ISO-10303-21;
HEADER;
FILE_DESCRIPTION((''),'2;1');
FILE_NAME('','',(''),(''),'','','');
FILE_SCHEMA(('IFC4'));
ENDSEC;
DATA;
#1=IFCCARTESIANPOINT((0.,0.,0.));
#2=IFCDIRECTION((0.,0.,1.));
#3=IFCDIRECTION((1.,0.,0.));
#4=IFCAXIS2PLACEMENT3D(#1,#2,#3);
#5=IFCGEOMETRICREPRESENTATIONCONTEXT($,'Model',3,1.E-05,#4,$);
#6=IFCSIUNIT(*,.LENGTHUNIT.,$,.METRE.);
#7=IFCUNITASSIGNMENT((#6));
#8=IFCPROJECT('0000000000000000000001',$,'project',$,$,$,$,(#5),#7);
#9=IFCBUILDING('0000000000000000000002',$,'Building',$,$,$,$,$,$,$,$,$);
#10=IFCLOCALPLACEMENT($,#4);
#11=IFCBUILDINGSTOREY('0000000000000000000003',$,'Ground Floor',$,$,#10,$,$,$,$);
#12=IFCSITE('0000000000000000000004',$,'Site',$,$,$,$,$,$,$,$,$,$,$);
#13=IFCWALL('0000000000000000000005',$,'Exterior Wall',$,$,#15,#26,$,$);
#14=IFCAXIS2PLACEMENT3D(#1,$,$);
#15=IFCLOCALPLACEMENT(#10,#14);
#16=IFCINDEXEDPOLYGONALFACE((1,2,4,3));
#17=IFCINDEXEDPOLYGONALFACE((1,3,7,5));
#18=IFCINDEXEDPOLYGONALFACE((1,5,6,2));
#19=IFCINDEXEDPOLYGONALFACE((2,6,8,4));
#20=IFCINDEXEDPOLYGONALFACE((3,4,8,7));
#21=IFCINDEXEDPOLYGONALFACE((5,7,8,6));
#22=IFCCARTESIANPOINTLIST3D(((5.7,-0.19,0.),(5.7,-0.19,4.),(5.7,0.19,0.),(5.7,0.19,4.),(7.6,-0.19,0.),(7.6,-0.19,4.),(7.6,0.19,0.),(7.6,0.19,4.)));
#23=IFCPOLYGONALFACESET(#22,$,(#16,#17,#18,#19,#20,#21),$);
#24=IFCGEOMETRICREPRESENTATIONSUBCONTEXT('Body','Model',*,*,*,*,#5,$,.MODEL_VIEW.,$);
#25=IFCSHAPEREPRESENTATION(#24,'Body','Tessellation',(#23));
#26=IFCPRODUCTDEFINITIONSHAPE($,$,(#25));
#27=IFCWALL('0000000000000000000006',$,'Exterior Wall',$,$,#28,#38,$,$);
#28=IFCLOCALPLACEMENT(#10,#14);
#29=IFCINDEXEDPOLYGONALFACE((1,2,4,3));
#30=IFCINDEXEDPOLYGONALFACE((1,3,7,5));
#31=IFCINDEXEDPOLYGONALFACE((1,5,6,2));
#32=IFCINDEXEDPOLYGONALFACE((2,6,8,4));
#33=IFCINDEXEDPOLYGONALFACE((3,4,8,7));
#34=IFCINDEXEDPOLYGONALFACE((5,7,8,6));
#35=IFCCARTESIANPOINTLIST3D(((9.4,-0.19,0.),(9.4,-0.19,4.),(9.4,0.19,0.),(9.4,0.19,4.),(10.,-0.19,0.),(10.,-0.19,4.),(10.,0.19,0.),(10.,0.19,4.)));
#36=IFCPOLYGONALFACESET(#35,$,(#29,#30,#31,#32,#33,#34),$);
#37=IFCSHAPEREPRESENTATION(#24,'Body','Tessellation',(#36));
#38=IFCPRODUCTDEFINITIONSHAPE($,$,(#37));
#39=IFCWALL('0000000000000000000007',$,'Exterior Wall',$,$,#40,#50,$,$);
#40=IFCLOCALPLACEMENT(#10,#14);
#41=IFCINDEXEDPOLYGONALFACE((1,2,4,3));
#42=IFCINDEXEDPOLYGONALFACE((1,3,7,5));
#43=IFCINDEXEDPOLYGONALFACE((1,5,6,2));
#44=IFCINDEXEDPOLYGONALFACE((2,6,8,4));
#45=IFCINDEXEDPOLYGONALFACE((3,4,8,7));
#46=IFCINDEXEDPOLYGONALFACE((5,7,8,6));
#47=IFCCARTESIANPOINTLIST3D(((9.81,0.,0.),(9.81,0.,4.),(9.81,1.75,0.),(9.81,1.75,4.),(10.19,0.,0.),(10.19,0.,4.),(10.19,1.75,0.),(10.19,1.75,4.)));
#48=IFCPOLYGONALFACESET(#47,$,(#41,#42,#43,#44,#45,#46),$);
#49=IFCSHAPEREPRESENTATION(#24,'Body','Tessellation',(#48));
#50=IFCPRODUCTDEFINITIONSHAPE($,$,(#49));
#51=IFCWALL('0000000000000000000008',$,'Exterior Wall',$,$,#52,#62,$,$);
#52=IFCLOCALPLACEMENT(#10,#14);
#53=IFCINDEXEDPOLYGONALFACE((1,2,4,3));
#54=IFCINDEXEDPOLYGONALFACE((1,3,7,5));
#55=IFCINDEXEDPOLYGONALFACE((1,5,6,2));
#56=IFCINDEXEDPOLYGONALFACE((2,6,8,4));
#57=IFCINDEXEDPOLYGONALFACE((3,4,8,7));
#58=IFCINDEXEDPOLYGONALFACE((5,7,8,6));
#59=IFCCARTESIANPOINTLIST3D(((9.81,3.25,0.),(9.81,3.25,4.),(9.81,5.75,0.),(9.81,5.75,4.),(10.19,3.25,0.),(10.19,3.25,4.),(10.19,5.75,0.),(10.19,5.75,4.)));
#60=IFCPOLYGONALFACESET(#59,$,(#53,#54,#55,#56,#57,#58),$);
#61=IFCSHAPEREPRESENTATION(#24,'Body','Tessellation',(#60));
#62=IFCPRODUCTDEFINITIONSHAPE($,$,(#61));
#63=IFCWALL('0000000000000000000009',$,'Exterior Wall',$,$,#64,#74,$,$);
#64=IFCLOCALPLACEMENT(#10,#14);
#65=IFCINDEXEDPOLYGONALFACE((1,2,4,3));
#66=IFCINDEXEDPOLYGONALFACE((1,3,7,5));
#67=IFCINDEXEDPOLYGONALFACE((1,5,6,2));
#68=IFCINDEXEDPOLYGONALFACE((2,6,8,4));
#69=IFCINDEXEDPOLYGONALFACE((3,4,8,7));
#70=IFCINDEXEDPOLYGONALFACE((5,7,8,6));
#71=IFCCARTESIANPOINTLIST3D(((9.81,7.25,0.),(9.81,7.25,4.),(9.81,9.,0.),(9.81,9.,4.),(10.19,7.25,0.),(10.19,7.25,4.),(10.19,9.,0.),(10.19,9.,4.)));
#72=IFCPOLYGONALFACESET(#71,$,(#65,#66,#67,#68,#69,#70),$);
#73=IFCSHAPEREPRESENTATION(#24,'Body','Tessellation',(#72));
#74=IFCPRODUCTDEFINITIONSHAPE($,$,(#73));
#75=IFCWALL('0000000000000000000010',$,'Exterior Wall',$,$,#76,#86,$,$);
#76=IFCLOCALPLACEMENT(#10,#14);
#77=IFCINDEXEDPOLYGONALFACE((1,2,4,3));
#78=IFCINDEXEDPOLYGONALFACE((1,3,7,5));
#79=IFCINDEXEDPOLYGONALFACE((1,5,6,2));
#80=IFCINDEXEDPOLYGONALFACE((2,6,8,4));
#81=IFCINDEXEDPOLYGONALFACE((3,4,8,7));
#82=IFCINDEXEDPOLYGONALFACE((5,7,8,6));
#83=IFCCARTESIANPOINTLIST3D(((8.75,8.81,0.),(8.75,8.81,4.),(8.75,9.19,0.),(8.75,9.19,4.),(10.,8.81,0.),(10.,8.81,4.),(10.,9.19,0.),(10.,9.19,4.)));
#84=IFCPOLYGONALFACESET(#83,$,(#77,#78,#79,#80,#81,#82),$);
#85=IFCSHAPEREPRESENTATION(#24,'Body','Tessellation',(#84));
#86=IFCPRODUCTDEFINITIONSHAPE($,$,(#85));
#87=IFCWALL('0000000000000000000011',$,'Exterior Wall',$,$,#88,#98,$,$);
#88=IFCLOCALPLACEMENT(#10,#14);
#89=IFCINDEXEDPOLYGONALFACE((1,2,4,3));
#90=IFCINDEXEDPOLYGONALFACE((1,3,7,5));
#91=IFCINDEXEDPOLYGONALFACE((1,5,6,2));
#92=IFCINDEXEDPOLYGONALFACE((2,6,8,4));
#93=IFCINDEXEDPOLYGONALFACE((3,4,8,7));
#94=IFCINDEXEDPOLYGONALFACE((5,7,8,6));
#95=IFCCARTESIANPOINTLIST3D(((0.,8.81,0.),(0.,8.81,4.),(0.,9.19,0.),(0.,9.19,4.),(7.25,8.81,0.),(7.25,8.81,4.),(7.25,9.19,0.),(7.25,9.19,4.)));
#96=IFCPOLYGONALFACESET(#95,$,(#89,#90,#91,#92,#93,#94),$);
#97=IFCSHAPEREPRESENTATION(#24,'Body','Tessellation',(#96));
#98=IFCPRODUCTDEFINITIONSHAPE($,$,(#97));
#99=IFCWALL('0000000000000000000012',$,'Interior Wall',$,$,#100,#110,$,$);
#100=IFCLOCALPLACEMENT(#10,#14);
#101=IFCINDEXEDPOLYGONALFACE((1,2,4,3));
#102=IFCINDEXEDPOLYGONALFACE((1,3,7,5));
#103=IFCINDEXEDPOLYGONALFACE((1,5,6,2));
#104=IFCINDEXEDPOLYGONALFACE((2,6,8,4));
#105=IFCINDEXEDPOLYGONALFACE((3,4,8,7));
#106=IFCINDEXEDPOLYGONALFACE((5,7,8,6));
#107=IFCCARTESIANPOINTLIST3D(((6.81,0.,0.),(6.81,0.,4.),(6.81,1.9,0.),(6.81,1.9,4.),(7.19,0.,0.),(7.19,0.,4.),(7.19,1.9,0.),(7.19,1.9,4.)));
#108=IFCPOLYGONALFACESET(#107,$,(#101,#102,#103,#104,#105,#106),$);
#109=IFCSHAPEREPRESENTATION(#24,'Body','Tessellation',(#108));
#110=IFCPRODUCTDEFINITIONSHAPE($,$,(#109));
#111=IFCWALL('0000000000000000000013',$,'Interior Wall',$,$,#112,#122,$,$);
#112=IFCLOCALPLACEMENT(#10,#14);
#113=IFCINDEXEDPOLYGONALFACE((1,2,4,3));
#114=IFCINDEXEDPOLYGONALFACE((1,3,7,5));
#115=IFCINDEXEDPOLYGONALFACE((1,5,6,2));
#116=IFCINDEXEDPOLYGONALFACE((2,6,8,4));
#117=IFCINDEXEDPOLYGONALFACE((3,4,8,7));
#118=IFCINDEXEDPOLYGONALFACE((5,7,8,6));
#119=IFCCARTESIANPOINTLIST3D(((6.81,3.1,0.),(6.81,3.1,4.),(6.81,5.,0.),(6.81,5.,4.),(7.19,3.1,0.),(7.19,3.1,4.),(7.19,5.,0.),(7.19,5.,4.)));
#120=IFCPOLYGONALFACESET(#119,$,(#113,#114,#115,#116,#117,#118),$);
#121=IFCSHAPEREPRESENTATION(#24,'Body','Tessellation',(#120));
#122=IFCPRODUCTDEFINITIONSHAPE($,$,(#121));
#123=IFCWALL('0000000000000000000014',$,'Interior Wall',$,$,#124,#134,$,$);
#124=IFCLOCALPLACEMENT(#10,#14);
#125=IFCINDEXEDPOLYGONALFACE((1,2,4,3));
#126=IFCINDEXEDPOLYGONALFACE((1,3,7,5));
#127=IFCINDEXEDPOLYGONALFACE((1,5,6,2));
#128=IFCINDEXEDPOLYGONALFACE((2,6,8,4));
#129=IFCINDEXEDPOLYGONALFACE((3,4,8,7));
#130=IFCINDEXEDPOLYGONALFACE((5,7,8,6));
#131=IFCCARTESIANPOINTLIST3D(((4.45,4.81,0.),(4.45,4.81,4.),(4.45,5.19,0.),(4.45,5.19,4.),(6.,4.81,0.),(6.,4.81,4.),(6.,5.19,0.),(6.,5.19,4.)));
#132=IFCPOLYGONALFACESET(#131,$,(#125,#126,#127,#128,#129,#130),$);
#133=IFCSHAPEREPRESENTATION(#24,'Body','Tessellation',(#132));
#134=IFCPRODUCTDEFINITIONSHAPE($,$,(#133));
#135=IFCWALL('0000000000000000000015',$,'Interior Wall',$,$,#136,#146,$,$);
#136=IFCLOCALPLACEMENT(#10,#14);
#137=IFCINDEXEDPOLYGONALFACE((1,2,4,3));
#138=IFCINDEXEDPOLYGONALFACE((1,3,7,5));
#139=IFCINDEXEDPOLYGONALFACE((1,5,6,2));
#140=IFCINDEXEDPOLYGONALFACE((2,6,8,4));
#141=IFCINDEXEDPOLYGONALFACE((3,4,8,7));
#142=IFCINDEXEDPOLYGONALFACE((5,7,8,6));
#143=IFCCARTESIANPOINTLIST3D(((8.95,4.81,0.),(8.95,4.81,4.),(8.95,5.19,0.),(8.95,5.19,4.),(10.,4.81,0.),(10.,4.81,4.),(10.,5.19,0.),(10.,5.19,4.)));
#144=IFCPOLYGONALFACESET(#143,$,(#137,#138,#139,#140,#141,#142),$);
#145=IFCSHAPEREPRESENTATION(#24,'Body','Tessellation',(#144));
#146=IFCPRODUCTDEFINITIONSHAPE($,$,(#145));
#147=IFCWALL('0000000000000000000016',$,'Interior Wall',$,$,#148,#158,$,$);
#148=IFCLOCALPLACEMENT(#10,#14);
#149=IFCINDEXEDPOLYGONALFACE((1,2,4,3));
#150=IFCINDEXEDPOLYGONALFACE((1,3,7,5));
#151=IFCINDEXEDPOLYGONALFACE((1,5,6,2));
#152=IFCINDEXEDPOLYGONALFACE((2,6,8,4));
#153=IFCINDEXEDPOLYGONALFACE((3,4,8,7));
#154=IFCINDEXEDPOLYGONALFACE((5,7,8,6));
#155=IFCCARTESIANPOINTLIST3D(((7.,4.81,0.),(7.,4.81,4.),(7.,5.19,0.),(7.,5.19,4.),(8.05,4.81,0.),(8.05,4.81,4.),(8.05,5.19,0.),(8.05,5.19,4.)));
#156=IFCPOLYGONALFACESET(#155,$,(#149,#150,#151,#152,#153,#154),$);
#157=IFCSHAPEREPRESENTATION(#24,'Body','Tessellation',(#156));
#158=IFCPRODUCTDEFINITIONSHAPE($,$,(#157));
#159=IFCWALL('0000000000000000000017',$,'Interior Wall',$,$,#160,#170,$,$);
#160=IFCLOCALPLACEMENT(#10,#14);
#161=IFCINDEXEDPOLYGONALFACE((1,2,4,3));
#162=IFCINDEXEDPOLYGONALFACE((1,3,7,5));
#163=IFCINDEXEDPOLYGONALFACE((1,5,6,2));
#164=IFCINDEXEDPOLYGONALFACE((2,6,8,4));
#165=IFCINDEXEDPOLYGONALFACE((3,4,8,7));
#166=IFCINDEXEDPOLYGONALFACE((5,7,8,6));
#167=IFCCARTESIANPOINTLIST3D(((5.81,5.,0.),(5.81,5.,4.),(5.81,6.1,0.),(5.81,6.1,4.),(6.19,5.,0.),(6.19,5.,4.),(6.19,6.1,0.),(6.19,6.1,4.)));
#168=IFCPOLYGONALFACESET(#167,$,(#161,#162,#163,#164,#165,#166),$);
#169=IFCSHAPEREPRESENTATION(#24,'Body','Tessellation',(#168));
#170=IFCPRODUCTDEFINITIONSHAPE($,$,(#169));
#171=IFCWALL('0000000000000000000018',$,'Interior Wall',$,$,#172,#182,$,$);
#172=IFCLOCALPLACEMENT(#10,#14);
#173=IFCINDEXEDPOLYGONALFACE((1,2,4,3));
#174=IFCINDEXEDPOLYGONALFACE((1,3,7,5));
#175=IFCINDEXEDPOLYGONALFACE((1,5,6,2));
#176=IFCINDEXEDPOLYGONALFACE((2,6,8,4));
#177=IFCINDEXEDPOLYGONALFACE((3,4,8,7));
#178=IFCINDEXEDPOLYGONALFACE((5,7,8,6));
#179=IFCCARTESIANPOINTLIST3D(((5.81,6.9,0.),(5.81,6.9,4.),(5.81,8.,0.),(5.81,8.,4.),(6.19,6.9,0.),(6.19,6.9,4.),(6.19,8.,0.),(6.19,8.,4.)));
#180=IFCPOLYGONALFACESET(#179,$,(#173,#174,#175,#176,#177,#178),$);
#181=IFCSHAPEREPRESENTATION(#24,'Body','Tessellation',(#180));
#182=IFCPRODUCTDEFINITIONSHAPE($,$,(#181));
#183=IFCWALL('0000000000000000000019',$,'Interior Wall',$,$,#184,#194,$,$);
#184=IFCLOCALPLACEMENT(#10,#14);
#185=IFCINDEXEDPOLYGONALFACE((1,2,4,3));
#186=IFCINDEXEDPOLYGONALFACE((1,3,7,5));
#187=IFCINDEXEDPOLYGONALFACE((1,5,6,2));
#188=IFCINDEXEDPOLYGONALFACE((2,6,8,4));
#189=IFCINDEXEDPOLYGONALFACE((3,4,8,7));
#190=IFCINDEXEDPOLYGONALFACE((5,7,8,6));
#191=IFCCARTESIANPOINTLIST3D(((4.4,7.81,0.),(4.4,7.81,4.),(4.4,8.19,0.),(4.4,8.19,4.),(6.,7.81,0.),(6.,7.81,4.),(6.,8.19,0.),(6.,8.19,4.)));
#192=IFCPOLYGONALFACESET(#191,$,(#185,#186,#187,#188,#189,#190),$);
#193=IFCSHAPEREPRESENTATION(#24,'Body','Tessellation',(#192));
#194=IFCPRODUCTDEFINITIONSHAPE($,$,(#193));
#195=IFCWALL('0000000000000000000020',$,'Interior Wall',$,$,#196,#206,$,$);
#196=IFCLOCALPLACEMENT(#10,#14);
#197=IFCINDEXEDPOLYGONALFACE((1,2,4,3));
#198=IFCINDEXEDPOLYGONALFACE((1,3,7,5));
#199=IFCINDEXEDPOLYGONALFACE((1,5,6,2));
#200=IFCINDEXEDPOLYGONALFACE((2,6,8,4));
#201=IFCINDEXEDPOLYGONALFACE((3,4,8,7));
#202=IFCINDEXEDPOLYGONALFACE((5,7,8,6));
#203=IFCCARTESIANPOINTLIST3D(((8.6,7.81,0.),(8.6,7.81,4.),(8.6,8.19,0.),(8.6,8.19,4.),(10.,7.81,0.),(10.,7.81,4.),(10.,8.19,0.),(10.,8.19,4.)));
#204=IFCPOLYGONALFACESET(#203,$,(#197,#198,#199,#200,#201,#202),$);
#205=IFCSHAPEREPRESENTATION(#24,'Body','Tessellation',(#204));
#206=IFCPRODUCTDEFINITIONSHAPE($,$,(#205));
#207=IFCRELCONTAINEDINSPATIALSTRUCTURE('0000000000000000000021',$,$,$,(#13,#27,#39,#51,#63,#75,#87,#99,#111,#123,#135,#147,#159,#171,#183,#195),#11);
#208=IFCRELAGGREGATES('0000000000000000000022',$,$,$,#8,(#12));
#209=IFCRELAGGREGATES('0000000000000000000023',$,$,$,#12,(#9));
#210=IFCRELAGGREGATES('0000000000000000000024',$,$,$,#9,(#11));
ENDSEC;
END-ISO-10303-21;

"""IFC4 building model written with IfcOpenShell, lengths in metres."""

from ifc_helpers import new_model, si_unit, frame, origin_with_axes, place, context, subcontext, project, spatial, indexed_curve, outline, extrude, element, save


model = new_model("IFC4")

# Units and contexts
model_context = context("Model", 3, precision=1e-05, world=origin_with_axes())
body_context = subcontext(model_context, "Body", "Model", "MODEL_VIEW")
ifc_project = project(units=[si_unit("LENGTHUNIT", "METRE")], contexts=[model_context])

# Site, building, storey
site = spatial("IfcSite", under=ifc_project, Name="Site")
building = spatial("IfcBuilding", under=site, Name="Building")
storey_placement = place(None, origin_with_axes())
storey = spatial("IfcBuildingStorey", under=building, at=storey_placement, Name="Ground Floor")

# Walls
wall_1_placement = place(storey_placement, frame((5.7, 0.0, 0.0), z_axis=(0.0, 0.0, 1.0), x_axis=(1.0, 0.0, 0.0)))
element("IfcWall", 1, at=wall_1_placement, inside=storey, Name="Exterior Wall", context=body_context, shape_type="SweptSolid", body=[
    extrude(outline(indexed_curve([(0.0, 0.0), (0.0, 0.38), (1.9, 0.38), (1.9, 0.0), (0.0, 0.0)], self_intersect=False)), frame((0.0, -0.19, 0.0), z_axis=(0.0, 0.0, 1.0), x_axis=(1.0, 0.0, 0.0)), (0.0, 0.0, 1.0), 4.0),
])
wall_2_placement = place(storey_placement, frame((9.4, 0.0, 0.0), z_axis=(0.0, 0.0, 1.0), x_axis=(1.0, 0.0, 0.0)))
element("IfcWall", 2, at=wall_2_placement, inside=storey, Name="Exterior Wall", context=body_context, shape_type="SweptSolid", body=[
    extrude(outline(indexed_curve([(0.0, 0.0), (0.0, 0.38), (0.6, 0.38), (0.6, 0.0), (0.0, 0.0)], self_intersect=False)), frame((0.0, -0.19, 0.0), z_axis=(0.0, 0.0, 1.0), x_axis=(1.0, 0.0, 0.0)), (0.0, 0.0, 1.0), 4.0),
])
wall_3_placement = place(storey_placement, frame((10.0, 0.0, 0.0), z_axis=(0.0, 0.0, 1.0), x_axis=(0.0, 1.0, 0.0)))
element("IfcWall", 3, at=wall_3_placement, inside=storey, Name="Exterior Wall", context=body_context, shape_type="SweptSolid", body=[
    extrude(outline(indexed_curve([(0.0, 0.0), (0.0, 0.38), (1.75, 0.38), (1.75, 0.0), (0.0, 0.0)], self_intersect=False)), frame((0.0, -0.19, 0.0), z_axis=(0.0, 0.0, 1.0), x_axis=(1.0, 0.0, 0.0)), (0.0, 0.0, 1.0), 4.0),
])
wall_4_placement = place(storey_placement, frame((10.0, 3.25, 0.0), z_axis=(0.0, 0.0, 1.0), x_axis=(0.0, 1.0, 0.0)))
element("IfcWall", 4, at=wall_4_placement, inside=storey, Name="Exterior Wall", context=body_context, shape_type="SweptSolid", body=[
    extrude(outline(indexed_curve([(0.0, 0.0), (0.0, 0.38), (2.5, 0.38), (2.5, 0.0), (0.0, 0.0)], self_intersect=False)), frame((0.0, -0.19, 0.0), z_axis=(0.0, 0.0, 1.0), x_axis=(1.0, 0.0, 0.0)), (0.0, 0.0, 1.0), 4.0),
])
wall_5_placement = place(storey_placement, frame((10.0, 7.25, 0.0), z_axis=(0.0, 0.0, 1.0), x_axis=(0.0, 1.0, 0.0)))
element("IfcWall", 5, at=wall_5_placement, inside=storey, Name="Exterior Wall", context=body_context, shape_type="SweptSolid", body=[
    extrude(outline(indexed_curve([(0.0, 0.0), (0.0, 0.38), (1.75, 0.38), (1.75, 0.0), (0.0, 0.0)], self_intersect=False)), frame((0.0, -0.19, 0.0), z_axis=(0.0, 0.0, 1.0), x_axis=(1.0, 0.0, 0.0)), (0.0, 0.0, 1.0), 4.0),
])
wall_6_placement = place(storey_placement, frame((10.0, 9.0, 0.0), z_axis=(0.0, 0.0, 1.0), x_axis=(-1.0, 0.0, 0.0)))
element("IfcWall", 6, at=wall_6_placement, inside=storey, Name="Exterior Wall", context=body_context, shape_type="SweptSolid", body=[
    extrude(outline(indexed_curve([(0.0, 0.0), (0.0, 0.38), (1.25, 0.38), (1.25, 0.0), (0.0, 0.0)], self_intersect=False)), frame((0.0, -0.19, 0.0), z_axis=(0.0, 0.0, 1.0), x_axis=(1.0, 0.0, 0.0)), (0.0, 0.0, 1.0), 4.0),
])
wall_7_placement = place(storey_placement, frame((7.25, 9.0, 0.0), z_axis=(0.0, 0.0, 1.0), x_axis=(-1.0, 0.0, 0.0)))
element("IfcWall", 7, at=wall_7_placement, inside=storey, Name="Exterior Wall", context=body_context, shape_type="SweptSolid", body=[
    extrude(outline(indexed_curve([(0.0, 0.0), (0.0, 0.38), (7.25, 0.38), (7.25, 0.0), (0.0, 0.0)], self_intersect=False)), frame((0.0, -0.19, 0.0), z_axis=(0.0, 0.0, 1.0), x_axis=(1.0, 0.0, 0.0)), (0.0, 0.0, 1.0), 4.0),
])
for number, where, z_axis, x_axis, name in (
    (8, (7.0, 0.0, 0.0), (0.0, 0.0, 1.0), (0.0, 1.0, 0.0), "Interior Wall"),
    (9, (7.0, 3.1, 0.0), (0.0, 0.0, 1.0), (0.0, 1.0, 0.0), "Interior Wall"),
):
    element("IfcWall", number, at=place(storey_placement, frame(where, z_axis=z_axis, x_axis=x_axis)), inside=storey, Name=name, context=body_context, shape_type="SweptSolid", body=[
        extrude(outline(indexed_curve([(0.0, 0.0), (0.0, 0.38), (1.9, 0.38), (1.9, 0.0), (0.0, 0.0)], self_intersect=False)), frame((0.0, -0.19, 0.0), z_axis=(0.0, 0.0, 1.0), x_axis=(1.0, 0.0, 0.0)), (0.0, 0.0, 1.0), 4.0),
    ])
wall_8_placement = place(storey_placement, frame((6.0, 5.0, 0.0), z_axis=(0.0, 0.0, 1.0), x_axis=(-1.0, 0.0, 0.0)))
element("IfcWall", 10, at=wall_8_placement, inside=storey, Name="Interior Wall", context=body_context, shape_type="SweptSolid", body=[
    extrude(outline(indexed_curve([(0.0, 0.0), (0.0, 0.38), (1.55, 0.38), (1.55, 0.0), (0.0, 0.0)], self_intersect=False)), frame((0.0, -0.19, 0.0), z_axis=(0.0, 0.0, 1.0), x_axis=(1.0, 0.0, 0.0)), (0.0, 0.0, 1.0), 4.0),
])
for number, where, z_axis, x_axis, name in (
    (11, (10.0, 5.0, 0.0), (0.0, 0.0, 1.0), (-1.0, 0.0, 0.0), "Interior Wall"),
    (12, (8.05, 5.0, 0.0), (0.0, 0.0, 1.0), (-1.0, 0.0, 0.0), "Interior Wall"),
):
    element("IfcWall", number, at=place(storey_placement, frame(where, z_axis=z_axis, x_axis=x_axis)), inside=storey, Name=name, context=body_context, shape_type="SweptSolid", body=[
        extrude(outline(indexed_curve([(0.0, 0.0), (0.0, 0.38), (1.05, 0.38), (1.05, 0.0), (0.0, 0.0)], self_intersect=False)), frame((0.0, -0.19, 0.0), z_axis=(0.0, 0.0, 1.0), x_axis=(1.0, 0.0, 0.0)), (0.0, 0.0, 1.0), 4.0),
    ])
for number, where, z_axis, x_axis, name in (
    (13, (6.0, 5.0, 0.0), (0.0, 0.0, 1.0), (0.0, 1.0, 0.0), "Interior Wall"),
    (14, (6.0, 6.9, 0.0), (0.0, 0.0, 1.0), (0.0, 1.0, 0.0), "Interior Wall"),
):
    element("IfcWall", number, at=place(storey_placement, frame(where, z_axis=z_axis, x_axis=x_axis)), inside=storey, Name=name, context=body_context, shape_type="SweptSolid", body=[
        extrude(outline(indexed_curve([(0.0, 0.0), (0.0, 0.38), (1.1, 0.38), (1.1, 0.0), (0.0, 0.0)], self_intersect=False)), frame((0.0, -0.19, 0.0), z_axis=(0.0, 0.0, 1.0), x_axis=(1.0, 0.0, 0.0)), (0.0, 0.0, 1.0), 4.0),
    ])
wall_9_placement = place(storey_placement, frame((6.0, 8.0, 0.0), z_axis=(0.0, 0.0, 1.0), x_axis=(-1.0, 0.0, 0.0)))
element("IfcWall", 15, at=wall_9_placement, inside=storey, Name="Interior Wall", context=body_context, shape_type="SweptSolid", body=[
    extrude(outline(indexed_curve([(0.0, 0.0), (0.0, 0.38), (1.6, 0.38), (1.6, 0.0), (0.0, 0.0)], self_intersect=False)), frame((0.0, -0.19, 0.0), z_axis=(0.0, 0.0, 1.0), x_axis=(1.0, 0.0, 0.0)), (0.0, 0.0, 1.0), 4.0),
])
for number, where, z_axis, x_axis, name in (
    (16, (10.0, 8.0, 0.0), (0.0, 0.0, 1.0), (-1.0, 0.0, 0.0), "Interior Wall"),
):
    element("IfcWall", number, at=place(storey_placement, frame(where, z_axis=z_axis, x_axis=x_axis)), inside=storey, Name=name, context=body_context, shape_type="SweptSolid", body=[
        extrude(outline(indexed_curve([(0.0, 0.0), (0.0, 0.38), (1.4, 0.38), (1.4, 0.0), (0.0, 0.0)], self_intersect=False)), frame((0.0, -0.19, 0.0), z_axis=(0.0, 0.0, 1.0), x_axis=(1.0, 0.0, 0.0)), (0.0, 0.0, 1.0), 4.0),
    ])

save(model, "model.ifc")
